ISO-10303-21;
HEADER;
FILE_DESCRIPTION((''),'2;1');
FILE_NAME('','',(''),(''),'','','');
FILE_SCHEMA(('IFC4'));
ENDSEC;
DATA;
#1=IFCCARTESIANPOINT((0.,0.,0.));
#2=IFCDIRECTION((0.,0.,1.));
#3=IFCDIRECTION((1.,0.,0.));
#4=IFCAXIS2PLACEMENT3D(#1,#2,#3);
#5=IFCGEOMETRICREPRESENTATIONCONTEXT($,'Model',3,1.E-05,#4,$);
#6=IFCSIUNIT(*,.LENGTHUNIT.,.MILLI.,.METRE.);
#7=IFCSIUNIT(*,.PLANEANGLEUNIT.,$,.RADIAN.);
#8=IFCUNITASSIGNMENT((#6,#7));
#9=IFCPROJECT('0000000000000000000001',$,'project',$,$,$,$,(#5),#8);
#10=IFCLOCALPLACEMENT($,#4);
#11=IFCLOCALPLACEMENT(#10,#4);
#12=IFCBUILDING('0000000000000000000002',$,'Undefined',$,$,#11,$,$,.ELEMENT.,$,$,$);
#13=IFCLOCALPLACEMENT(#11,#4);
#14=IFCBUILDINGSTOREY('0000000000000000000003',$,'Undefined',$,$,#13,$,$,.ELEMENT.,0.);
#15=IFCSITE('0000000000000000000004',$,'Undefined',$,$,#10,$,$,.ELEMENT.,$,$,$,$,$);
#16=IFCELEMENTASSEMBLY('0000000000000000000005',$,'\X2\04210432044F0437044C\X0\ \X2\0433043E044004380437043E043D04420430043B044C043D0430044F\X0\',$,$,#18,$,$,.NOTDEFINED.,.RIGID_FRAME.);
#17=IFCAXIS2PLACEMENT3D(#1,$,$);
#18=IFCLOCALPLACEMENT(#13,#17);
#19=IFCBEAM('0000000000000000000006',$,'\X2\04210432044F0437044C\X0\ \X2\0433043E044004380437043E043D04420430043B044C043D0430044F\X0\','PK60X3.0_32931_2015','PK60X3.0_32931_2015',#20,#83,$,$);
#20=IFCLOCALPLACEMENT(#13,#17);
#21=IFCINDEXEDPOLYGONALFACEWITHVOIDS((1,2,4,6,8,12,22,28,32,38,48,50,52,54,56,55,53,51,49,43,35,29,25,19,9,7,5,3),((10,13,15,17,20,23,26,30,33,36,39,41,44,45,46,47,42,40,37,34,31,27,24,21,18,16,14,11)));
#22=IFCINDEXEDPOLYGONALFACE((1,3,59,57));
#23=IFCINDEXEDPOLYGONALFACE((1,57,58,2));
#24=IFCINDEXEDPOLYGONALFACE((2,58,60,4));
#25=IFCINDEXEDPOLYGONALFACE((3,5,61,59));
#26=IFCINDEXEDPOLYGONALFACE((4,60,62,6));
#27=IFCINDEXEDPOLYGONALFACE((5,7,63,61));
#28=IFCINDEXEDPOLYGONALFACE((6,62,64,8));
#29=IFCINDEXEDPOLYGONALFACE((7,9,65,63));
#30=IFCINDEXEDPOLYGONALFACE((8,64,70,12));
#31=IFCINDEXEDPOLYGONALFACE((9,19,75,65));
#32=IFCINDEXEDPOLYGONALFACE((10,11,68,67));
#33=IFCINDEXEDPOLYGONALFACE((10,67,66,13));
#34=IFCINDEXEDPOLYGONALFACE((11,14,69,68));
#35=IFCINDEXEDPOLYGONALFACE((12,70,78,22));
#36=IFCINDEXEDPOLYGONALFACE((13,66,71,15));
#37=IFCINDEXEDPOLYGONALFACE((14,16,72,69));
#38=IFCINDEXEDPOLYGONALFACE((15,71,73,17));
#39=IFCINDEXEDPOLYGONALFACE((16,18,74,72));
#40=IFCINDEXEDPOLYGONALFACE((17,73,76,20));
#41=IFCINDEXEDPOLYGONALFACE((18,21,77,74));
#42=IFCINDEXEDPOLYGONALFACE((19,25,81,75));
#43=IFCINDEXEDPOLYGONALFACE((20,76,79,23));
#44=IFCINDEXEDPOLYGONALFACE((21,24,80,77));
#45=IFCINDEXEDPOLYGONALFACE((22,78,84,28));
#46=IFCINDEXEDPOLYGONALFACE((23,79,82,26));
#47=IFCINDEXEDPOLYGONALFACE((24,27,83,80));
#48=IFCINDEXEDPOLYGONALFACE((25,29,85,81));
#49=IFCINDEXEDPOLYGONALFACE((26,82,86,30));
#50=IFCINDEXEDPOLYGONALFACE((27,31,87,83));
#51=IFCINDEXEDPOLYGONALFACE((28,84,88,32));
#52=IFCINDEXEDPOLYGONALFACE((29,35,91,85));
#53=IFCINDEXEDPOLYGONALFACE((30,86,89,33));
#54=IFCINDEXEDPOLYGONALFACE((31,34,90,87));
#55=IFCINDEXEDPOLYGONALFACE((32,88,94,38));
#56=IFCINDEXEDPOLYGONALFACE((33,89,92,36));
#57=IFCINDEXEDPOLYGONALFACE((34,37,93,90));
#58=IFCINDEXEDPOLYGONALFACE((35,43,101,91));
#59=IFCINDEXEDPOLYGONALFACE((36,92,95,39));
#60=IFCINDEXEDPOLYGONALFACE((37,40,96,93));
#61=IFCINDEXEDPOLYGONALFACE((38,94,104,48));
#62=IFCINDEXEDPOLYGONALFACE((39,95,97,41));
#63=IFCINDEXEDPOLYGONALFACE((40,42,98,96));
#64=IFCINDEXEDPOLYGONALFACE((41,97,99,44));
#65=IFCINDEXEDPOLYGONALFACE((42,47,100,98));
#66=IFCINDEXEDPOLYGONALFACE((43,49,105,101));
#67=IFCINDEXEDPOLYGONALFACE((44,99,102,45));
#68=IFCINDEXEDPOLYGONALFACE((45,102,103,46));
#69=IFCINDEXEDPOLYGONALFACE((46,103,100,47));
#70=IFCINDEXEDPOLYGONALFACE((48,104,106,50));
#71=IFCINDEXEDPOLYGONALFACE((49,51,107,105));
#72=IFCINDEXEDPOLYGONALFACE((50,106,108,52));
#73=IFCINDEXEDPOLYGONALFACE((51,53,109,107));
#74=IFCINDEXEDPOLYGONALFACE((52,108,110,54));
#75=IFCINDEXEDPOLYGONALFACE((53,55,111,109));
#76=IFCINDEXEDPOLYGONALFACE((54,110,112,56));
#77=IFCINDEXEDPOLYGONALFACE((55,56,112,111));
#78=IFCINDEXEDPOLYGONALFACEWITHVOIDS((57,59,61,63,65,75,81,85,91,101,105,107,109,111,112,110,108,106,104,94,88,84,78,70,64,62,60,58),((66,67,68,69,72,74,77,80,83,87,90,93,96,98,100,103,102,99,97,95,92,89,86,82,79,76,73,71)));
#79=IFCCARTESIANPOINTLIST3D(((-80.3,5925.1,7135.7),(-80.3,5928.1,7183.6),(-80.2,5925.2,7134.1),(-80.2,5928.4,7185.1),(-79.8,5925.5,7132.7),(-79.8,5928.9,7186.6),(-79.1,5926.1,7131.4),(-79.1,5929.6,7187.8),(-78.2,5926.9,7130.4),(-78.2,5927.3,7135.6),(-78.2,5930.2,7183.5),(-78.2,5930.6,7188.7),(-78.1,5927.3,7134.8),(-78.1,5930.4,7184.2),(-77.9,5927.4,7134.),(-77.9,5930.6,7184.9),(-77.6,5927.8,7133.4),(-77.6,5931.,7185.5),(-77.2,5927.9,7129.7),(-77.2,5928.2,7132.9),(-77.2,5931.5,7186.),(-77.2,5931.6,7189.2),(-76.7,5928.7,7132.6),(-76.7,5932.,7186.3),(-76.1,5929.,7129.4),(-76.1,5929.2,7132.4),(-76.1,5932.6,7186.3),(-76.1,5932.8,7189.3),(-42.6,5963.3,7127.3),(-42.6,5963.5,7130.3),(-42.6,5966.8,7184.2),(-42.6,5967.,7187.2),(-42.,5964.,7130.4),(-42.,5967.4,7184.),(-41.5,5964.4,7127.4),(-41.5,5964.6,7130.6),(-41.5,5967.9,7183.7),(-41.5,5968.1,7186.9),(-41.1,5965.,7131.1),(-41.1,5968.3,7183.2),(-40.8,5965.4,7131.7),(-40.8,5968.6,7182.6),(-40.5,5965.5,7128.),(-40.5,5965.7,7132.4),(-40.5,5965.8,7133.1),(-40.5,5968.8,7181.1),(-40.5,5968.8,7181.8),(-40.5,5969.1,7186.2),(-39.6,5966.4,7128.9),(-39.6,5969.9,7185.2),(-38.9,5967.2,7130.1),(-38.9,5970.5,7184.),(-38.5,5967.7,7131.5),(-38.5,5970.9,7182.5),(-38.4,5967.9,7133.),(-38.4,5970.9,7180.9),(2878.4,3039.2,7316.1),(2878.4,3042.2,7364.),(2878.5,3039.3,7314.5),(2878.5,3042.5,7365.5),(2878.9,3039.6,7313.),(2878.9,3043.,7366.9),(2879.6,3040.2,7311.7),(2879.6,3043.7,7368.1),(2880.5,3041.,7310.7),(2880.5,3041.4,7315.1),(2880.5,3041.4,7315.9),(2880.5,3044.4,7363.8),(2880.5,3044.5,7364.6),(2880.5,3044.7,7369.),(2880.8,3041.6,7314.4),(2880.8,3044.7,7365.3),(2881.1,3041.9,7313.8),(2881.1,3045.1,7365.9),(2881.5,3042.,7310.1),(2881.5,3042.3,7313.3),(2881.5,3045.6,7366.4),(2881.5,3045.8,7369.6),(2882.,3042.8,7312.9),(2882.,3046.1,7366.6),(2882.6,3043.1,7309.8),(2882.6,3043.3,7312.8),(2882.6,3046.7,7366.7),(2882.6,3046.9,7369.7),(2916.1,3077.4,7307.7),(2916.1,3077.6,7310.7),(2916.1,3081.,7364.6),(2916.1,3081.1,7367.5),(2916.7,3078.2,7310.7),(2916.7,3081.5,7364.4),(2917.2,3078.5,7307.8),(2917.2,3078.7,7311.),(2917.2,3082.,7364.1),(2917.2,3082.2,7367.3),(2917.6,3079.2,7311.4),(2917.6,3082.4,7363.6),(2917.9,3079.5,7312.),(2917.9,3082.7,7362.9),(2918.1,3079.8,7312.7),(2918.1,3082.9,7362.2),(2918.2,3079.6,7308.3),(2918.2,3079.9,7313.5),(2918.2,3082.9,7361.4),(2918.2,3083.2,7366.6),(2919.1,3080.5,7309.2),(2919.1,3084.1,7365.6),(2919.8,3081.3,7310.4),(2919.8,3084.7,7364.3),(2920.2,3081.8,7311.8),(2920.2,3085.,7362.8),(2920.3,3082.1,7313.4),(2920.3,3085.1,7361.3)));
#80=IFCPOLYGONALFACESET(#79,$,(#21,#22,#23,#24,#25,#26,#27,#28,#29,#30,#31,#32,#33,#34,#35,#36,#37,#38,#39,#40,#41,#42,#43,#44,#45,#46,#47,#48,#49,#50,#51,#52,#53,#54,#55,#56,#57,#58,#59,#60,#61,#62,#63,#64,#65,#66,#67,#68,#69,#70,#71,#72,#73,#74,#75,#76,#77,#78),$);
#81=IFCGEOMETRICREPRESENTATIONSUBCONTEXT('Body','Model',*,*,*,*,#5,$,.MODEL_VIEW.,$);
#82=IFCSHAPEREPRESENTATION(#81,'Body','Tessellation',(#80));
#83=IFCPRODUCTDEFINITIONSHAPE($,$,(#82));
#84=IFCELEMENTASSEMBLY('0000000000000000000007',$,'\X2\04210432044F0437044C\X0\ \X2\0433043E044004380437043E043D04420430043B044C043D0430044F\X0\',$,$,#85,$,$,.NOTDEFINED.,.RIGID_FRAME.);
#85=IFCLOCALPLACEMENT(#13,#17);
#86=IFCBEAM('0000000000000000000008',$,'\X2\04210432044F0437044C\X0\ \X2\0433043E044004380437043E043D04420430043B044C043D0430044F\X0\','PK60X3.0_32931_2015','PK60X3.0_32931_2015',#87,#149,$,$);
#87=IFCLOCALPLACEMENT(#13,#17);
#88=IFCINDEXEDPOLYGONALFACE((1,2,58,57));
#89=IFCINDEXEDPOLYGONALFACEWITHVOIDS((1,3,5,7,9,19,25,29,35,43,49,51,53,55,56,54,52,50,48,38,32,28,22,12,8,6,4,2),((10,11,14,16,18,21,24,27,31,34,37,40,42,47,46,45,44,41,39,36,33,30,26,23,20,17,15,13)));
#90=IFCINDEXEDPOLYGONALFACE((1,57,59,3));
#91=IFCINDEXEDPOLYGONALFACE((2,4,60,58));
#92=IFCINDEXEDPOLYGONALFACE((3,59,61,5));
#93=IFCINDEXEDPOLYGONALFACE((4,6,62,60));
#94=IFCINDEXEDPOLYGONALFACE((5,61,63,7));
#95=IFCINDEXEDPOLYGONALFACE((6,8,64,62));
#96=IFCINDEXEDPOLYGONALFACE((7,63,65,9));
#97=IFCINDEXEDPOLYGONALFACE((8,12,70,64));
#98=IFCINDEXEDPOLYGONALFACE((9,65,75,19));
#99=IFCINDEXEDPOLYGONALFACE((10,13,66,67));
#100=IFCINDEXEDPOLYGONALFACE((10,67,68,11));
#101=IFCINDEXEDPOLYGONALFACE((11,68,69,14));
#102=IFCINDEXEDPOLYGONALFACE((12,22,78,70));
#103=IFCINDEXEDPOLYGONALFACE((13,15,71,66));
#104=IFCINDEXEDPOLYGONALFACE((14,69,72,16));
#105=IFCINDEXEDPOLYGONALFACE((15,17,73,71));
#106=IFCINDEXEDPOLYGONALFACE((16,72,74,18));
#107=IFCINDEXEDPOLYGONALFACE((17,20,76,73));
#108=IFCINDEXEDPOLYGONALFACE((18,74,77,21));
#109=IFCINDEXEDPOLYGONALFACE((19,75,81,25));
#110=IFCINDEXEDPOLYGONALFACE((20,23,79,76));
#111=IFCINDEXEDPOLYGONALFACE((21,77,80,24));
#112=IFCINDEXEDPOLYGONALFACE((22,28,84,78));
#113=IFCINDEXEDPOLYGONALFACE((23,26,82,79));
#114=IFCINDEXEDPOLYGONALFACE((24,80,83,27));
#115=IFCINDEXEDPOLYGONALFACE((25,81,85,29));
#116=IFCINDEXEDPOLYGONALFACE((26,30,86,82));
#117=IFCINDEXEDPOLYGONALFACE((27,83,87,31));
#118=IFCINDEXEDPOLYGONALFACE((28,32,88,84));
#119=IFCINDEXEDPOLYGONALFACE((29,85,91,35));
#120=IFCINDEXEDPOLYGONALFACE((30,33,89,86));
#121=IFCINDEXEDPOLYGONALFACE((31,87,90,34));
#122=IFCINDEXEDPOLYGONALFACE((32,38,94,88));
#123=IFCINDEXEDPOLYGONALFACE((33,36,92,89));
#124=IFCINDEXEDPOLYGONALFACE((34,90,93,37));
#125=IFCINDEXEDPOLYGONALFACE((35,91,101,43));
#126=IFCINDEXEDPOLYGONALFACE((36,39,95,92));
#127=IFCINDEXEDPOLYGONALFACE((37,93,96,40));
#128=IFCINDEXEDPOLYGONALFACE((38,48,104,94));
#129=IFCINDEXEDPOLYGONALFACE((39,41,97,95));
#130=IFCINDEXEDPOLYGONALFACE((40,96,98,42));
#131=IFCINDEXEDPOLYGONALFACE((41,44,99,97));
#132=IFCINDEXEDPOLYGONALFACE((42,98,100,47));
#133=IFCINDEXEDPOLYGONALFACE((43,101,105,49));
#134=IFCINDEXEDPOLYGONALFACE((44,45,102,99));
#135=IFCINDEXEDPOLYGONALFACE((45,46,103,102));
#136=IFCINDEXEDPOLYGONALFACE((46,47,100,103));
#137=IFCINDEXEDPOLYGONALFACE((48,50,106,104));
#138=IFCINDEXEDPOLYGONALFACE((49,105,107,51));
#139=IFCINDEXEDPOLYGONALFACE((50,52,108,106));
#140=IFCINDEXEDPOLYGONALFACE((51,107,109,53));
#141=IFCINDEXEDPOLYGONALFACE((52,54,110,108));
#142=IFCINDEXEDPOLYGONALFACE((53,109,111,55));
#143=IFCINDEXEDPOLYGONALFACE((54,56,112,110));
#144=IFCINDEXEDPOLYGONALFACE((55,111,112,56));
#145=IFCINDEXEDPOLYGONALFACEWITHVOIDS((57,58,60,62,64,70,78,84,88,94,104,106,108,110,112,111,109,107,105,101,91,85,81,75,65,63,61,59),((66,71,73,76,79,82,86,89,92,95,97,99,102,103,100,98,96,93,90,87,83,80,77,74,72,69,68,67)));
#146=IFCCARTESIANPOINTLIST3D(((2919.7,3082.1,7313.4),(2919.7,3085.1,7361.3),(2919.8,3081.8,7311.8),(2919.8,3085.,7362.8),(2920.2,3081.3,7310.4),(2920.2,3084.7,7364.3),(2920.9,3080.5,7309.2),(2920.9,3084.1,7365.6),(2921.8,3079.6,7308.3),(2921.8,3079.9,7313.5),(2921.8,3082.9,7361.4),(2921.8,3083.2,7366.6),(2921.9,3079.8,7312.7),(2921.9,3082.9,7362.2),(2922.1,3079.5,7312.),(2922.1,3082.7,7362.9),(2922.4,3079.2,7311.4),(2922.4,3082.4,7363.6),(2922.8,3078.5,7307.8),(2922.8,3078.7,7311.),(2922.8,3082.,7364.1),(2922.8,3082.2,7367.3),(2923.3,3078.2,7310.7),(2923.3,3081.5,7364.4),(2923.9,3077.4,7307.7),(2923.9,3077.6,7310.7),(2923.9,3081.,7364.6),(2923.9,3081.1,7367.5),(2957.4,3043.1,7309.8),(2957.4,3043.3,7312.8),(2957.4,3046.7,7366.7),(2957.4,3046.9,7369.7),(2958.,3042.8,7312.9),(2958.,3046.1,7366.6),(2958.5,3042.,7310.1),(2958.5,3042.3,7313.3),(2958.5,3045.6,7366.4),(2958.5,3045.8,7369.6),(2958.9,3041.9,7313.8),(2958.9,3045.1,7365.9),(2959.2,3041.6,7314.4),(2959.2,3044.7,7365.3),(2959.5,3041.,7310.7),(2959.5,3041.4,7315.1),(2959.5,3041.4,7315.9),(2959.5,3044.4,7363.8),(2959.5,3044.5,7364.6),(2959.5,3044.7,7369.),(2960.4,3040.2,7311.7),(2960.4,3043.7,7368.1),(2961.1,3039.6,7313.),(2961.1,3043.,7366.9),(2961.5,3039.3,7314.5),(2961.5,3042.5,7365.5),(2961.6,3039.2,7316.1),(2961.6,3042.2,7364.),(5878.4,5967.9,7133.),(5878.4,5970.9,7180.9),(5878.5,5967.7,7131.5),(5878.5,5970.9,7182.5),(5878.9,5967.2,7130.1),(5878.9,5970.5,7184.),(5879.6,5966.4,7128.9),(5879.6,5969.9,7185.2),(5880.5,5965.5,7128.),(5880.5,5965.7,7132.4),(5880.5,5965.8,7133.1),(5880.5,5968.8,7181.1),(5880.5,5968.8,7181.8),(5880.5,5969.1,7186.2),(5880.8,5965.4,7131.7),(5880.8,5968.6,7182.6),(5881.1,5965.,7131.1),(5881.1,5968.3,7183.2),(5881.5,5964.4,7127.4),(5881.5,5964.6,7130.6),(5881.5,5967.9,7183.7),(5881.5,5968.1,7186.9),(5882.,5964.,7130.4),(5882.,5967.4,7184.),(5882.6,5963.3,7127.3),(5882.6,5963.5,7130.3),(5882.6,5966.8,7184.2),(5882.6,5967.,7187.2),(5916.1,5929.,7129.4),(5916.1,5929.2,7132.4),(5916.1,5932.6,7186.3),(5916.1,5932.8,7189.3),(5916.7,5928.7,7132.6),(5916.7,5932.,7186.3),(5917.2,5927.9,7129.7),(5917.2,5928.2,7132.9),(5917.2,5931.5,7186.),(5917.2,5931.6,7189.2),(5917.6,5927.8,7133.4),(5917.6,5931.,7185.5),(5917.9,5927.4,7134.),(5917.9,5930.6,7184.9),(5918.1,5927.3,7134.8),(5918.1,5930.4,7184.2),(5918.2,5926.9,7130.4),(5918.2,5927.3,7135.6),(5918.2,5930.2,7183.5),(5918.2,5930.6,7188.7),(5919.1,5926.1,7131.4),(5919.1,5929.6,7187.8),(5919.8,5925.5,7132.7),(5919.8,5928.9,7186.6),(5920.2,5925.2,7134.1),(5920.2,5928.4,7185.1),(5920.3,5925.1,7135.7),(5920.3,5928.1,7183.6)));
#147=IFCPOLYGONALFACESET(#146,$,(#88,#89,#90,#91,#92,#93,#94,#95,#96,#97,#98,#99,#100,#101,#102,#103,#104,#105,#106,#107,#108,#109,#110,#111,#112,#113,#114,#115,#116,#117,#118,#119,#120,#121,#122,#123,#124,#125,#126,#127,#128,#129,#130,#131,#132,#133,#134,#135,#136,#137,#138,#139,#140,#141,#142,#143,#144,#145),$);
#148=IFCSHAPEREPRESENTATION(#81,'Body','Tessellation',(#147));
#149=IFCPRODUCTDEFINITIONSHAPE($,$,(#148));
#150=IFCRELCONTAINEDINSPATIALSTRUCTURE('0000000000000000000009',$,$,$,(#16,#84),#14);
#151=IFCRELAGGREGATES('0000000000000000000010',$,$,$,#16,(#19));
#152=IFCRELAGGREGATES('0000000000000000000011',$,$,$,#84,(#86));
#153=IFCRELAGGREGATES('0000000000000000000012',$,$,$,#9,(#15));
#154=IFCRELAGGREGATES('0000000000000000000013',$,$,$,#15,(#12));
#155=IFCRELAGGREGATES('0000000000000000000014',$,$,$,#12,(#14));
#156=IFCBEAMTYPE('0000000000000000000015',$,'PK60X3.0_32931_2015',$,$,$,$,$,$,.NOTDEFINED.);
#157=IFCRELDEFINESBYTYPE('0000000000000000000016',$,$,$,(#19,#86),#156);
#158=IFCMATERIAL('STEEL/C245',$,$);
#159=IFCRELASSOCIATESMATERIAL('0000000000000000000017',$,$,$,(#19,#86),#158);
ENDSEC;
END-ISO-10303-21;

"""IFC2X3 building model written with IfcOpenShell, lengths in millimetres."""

from ifc_helpers import new_model, si_unit, frame, origin_with_axes, origin_2d_with_axis, place, context, subcontext, project, spatial, hollow_rectangle, extrude, material, type_object, element, aggregate, save


model = new_model("IFC2X3")

# Units and contexts
model_context = context("Model", 3, precision=1e-05, world=origin_with_axes())
body_context = subcontext(model_context, "Body", "Model", "MODEL_VIEW")
ifc_project = project(units=[si_unit("LENGTHUNIT", "METRE", prefix="MILLI"), si_unit("PLANEANGLEUNIT", "RADIAN")], contexts=[model_context])

# Site, building, storey
site_placement = place(None, origin_with_axes())
site = spatial("IfcSite", under=ifc_project, at=site_placement, Name="Undefined", CompositionType="ELEMENT")
building_placement = place(site_placement, origin_with_axes())
building = spatial("IfcBuilding", under=site, at=building_placement, Name="Undefined", CompositionType="ELEMENT")
storey_placement = place(building_placement, origin_with_axes())
storey = spatial("IfcBuildingStorey", under=building, at=storey_placement, Name="Undefined", CompositionType="ELEMENT", Elevation=0.0)

# Shared definitions
ifc_material = material(Name="STEEL/C245")

# Element assemblies, beams
assembly_1_placement = place(storey_placement, origin_with_axes())
assembly_1 = element("IfcElementAssembly", 1, at=assembly_1_placement, inside=storey, Name="Связь горизонтальная", AssemblyPlace="NOTDEFINED", PredefinedType="RIGID_FRAME")
beam_type_1 = type_object("IfcBeamType", Name="PK60X3.0_32931_2015", PredefinedType="NOTDEFINED")
beam_1_placement = place(assembly_1_placement, frame((-59.3, 5948.0, 7158.3), z_axis=(0.0, 0.062378, 0.998053), x_axis=(0.715179, -0.69758, 0.043599)))
beam_1 = element("IfcBeam", 2, at=beam_1_placement, type_object=beam_type_1, material=ifc_material, Name="Связь горизонтальная", Description="PK60X3.0_32931_2015", ObjectType="PK60X3.0_32931_2015", context=body_context, shape_type="SweptSolid", body=[
    extrude(hollow_rectangle(XDim=60.0, YDim=60.0, WallThickness=3.0, InnerFilletRadius=3.0, OuterFilletRadius=6.0, at=origin_2d_with_axis()), frame((4137.0, 0.0, 0.0), z_axis=(-1.0, 0.0, 0.0), x_axis=(0.0, -1.0, 0.0)), (0.0, 0.0, 1.0), 4137.0),
])
aggregate(assembly_1, [beam_1])
assembly_2_placement = place(storey_placement, origin_with_axes())
assembly_2 = element("IfcElementAssembly", 3, at=assembly_2_placement, inside=storey, Name="Связь горизонтальная", AssemblyPlace="NOTDEFINED", PredefinedType="RIGID_FRAME")
beam_2_placement = place(assembly_2_placement, frame((5899.3, 5948.0, 7158.3), z_axis=(0.0, 0.062378, 0.998053), x_axis=(-0.715179, -0.69758, 0.043599)))
beam_2 = element("IfcBeam", 4, at=beam_2_placement, type_object=beam_type_1, material=ifc_material, Name="Связь горизонтальная", Description="PK60X3.0_32931_2015", ObjectType="PK60X3.0_32931_2015", context=body_context, shape_type="SweptSolid", body=[
    extrude(hollow_rectangle(XDim=60.0, YDim=60.0, WallThickness=3.0, InnerFilletRadius=3.0, OuterFilletRadius=6.0, at=origin_2d_with_axis()), frame((4137.0, 0.0, 0.0), z_axis=(-1.0, 0.0, 0.0), x_axis=(0.0, -1.0, 0.0)), (0.0, 0.0, 1.0), 4137.0),
])
aggregate(assembly_2, [beam_2])

save(model, "model.ifc")
